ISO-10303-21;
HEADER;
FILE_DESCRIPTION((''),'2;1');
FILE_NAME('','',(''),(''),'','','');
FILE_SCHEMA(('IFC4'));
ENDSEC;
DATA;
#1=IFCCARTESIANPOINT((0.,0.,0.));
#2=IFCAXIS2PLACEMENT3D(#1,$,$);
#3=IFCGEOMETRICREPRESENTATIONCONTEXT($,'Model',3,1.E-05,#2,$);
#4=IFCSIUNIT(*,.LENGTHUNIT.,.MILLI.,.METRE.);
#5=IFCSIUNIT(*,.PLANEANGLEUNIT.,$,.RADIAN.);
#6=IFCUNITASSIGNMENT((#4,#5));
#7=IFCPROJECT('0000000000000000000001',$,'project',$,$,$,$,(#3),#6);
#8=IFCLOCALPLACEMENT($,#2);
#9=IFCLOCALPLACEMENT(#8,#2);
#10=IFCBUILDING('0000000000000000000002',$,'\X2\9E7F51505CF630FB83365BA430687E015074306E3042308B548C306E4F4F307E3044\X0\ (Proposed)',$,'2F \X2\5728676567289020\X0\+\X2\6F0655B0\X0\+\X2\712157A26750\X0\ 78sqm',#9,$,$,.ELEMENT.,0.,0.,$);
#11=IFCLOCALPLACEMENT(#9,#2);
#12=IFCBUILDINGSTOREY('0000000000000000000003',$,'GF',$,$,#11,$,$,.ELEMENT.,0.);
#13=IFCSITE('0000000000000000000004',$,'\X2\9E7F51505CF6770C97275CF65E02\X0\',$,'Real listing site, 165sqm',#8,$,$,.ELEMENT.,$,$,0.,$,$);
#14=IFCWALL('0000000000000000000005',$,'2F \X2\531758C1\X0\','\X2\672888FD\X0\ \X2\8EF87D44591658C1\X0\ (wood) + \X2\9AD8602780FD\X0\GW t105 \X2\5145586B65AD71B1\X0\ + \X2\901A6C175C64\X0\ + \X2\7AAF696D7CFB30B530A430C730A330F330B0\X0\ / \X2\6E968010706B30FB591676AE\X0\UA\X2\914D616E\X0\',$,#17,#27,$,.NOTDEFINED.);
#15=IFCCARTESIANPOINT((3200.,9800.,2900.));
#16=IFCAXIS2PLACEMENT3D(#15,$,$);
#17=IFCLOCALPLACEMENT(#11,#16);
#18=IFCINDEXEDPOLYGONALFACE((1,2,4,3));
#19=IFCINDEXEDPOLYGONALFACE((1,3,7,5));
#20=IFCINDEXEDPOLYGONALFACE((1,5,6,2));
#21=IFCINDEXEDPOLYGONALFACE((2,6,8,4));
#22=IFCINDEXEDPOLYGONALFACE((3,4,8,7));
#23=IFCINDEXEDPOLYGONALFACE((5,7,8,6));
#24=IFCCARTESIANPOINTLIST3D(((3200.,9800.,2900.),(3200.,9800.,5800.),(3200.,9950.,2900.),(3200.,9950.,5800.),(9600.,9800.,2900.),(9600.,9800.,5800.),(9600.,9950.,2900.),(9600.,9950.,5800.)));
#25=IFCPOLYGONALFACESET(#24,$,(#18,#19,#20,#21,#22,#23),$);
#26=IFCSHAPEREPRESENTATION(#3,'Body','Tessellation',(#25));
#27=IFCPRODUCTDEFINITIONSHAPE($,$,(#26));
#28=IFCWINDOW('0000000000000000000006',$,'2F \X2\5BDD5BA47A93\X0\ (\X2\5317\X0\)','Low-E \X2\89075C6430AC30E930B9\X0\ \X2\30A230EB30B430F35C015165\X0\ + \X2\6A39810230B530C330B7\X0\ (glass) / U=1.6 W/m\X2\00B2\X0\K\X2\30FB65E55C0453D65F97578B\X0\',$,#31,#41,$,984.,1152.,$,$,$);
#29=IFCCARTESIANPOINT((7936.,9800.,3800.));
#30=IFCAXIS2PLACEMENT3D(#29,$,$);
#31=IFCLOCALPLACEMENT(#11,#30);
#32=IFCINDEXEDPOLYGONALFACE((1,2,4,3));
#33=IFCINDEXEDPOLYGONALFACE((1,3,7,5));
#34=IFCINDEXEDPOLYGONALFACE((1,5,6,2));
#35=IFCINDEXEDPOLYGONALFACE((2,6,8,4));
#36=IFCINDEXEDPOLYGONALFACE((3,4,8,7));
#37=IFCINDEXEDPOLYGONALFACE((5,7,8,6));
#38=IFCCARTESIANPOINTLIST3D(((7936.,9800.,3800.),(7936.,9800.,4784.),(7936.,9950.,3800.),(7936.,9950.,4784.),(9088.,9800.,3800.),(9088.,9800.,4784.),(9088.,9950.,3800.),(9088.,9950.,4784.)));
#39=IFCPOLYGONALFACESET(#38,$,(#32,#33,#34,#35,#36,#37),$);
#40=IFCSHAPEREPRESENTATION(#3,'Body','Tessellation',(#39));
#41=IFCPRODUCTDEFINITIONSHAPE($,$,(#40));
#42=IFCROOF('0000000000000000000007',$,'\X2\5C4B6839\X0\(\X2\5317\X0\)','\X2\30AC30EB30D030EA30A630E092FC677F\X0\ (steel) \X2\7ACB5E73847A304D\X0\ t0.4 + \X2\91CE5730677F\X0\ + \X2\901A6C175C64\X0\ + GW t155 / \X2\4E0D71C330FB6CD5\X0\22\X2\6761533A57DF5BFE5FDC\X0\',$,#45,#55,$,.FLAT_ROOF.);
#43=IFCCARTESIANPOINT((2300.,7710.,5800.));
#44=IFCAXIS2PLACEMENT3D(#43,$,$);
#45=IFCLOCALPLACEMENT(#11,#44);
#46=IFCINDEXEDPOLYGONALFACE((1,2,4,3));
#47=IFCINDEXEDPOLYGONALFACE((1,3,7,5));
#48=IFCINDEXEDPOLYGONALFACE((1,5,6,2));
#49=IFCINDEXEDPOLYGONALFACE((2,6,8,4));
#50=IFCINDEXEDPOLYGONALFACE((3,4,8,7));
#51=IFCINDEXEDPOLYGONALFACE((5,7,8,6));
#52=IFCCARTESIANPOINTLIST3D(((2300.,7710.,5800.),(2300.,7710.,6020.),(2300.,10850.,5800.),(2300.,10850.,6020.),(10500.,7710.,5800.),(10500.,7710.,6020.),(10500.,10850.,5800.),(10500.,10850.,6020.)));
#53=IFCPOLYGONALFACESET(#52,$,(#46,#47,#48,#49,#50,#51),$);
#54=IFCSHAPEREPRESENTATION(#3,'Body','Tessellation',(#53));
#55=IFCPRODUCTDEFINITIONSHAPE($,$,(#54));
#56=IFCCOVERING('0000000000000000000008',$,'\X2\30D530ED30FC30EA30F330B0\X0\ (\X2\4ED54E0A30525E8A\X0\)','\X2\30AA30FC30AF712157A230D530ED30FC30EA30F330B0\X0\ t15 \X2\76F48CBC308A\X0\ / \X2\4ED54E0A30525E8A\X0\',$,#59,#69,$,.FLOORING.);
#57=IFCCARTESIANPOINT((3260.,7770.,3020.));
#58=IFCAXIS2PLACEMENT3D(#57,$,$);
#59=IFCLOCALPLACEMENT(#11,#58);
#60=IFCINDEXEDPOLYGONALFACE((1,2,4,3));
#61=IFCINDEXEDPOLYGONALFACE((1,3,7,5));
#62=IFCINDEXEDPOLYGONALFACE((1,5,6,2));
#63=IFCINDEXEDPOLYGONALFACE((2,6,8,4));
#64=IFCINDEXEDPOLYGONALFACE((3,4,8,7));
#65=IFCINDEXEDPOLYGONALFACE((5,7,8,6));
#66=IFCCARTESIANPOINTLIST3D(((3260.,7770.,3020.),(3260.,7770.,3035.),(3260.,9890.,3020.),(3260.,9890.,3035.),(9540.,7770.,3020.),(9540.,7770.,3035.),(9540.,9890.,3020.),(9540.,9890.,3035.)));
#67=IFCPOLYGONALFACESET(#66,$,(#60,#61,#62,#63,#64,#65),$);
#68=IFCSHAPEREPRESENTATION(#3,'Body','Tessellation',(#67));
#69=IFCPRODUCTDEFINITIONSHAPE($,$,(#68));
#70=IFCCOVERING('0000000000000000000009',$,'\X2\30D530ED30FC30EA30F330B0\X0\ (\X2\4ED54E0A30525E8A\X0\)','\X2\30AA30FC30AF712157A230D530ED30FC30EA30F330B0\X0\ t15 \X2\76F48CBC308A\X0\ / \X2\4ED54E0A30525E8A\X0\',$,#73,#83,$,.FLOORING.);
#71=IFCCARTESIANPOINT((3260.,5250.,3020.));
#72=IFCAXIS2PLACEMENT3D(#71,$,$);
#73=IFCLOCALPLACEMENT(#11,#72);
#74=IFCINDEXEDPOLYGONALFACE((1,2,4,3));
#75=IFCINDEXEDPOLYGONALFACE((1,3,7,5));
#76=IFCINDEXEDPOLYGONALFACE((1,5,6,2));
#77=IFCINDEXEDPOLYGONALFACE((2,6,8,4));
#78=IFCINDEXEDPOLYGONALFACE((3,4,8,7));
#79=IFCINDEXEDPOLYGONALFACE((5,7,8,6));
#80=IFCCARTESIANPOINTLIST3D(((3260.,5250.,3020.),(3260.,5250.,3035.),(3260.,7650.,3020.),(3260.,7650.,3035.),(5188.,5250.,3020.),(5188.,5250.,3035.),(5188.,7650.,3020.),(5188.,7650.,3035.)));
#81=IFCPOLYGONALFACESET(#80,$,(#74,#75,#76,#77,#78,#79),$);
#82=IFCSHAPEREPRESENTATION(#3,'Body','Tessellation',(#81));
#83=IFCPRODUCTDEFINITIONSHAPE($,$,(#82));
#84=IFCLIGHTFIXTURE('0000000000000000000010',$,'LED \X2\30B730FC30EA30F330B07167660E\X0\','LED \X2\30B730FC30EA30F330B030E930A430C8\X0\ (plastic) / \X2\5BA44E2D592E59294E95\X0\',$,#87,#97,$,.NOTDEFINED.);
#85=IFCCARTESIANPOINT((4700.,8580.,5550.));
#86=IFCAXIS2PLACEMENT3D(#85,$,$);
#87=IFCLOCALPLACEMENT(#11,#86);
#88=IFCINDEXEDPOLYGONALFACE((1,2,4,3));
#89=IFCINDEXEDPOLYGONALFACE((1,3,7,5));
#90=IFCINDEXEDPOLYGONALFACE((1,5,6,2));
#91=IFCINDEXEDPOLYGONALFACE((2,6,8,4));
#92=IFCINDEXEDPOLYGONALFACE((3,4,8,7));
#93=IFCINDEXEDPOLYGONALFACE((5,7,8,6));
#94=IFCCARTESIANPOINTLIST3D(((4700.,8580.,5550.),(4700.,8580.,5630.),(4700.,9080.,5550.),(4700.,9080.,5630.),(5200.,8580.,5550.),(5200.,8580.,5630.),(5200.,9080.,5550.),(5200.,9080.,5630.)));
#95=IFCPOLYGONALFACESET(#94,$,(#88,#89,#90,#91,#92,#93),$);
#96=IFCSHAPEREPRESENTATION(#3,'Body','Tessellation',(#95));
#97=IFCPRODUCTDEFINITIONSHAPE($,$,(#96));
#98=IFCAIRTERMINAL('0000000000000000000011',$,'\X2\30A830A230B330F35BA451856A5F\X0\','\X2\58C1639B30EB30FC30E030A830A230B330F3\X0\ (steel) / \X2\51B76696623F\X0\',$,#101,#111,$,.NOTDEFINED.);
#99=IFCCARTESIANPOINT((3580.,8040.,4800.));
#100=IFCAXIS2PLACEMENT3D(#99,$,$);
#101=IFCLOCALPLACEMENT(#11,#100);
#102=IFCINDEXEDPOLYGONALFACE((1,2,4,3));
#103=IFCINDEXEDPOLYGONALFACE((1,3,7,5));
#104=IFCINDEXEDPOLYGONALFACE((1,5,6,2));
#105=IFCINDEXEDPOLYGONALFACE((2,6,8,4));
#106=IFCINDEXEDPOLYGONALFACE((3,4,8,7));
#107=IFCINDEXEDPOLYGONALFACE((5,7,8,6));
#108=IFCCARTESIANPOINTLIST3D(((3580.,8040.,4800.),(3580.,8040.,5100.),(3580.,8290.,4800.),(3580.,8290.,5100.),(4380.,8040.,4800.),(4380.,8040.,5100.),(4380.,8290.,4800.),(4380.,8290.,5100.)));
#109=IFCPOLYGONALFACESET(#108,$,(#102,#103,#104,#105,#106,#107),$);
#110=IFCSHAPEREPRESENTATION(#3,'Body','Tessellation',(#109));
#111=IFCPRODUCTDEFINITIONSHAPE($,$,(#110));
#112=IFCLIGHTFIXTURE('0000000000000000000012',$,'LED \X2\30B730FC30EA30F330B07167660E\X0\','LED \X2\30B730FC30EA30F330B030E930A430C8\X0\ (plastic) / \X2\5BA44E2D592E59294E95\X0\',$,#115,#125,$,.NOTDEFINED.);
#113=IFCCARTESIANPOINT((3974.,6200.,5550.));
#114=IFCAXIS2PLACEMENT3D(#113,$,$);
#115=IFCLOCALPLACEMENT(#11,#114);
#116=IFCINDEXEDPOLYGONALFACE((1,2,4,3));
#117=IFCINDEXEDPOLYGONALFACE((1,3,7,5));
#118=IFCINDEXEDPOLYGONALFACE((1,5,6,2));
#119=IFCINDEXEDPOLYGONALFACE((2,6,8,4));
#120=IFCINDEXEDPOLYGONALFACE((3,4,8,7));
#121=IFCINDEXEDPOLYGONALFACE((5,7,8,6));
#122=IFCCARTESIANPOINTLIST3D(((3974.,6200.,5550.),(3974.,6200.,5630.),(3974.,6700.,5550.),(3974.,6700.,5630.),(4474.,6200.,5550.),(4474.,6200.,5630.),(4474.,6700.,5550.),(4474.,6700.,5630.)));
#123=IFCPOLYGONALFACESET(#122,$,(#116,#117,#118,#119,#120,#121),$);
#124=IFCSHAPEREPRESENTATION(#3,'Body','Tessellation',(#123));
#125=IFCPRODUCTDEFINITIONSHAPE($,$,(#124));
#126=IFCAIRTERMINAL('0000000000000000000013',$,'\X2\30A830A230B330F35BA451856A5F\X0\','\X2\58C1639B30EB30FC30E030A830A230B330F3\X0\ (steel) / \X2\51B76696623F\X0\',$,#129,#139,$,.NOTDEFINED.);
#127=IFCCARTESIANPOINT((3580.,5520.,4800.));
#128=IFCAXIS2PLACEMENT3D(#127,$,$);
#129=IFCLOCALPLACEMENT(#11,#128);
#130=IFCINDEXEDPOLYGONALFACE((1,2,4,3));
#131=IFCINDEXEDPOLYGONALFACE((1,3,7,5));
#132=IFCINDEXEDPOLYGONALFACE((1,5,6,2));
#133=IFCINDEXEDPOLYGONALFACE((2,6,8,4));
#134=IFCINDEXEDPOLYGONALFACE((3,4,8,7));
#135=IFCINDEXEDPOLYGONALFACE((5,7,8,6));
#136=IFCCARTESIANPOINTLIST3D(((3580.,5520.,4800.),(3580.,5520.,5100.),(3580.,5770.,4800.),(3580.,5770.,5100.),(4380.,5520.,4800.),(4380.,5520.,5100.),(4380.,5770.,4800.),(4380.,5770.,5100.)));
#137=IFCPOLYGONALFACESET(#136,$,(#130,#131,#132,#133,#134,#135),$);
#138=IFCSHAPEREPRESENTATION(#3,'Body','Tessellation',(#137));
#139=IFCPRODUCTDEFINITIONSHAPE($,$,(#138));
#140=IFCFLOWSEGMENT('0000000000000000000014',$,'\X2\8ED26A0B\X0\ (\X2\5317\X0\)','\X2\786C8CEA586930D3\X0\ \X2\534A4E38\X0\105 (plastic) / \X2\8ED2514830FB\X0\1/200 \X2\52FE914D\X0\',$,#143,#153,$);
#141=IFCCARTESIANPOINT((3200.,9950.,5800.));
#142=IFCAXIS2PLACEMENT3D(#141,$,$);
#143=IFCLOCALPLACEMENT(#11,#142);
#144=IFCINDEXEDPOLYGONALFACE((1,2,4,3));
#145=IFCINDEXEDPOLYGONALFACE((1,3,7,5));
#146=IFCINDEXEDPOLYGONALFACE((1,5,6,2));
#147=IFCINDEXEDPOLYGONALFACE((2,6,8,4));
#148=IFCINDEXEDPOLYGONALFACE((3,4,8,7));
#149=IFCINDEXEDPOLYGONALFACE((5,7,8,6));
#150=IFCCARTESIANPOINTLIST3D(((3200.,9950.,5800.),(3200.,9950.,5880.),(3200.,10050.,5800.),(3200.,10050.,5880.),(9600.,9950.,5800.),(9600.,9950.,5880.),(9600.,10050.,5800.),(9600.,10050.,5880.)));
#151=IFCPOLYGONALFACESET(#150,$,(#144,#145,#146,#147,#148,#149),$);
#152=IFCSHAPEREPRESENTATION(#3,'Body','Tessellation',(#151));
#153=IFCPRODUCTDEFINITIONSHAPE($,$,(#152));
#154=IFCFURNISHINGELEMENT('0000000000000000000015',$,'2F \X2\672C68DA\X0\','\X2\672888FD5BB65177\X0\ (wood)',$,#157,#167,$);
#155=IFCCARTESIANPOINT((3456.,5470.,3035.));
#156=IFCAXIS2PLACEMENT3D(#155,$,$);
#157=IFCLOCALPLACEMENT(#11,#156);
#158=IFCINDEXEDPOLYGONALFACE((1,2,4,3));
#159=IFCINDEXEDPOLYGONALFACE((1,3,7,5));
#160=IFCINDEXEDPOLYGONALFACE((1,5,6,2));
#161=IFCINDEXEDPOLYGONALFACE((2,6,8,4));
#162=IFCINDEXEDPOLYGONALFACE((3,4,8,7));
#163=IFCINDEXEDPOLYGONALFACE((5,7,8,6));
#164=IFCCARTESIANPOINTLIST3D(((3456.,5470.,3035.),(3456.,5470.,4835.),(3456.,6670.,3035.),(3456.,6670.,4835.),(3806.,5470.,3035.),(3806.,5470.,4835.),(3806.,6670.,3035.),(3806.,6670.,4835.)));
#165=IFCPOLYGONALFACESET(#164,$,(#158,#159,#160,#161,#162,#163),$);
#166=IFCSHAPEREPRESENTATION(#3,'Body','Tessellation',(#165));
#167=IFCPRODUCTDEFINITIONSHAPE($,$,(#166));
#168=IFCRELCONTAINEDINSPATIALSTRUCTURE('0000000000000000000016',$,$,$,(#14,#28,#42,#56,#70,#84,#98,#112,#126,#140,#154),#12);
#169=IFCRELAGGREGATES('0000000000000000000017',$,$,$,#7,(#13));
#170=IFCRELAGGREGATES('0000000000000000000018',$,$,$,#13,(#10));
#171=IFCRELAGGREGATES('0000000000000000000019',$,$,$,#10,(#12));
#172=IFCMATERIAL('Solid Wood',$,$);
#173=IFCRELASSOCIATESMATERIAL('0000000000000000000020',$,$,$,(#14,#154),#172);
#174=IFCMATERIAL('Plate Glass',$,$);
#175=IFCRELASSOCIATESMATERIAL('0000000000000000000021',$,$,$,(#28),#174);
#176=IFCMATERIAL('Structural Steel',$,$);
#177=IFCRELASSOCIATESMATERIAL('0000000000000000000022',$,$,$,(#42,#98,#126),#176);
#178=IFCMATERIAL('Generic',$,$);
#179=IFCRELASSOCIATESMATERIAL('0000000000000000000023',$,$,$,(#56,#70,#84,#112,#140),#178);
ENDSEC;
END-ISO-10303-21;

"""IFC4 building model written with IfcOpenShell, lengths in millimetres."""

from ifc_helpers import new_model, si_unit, frame, frame_2d, origin, place, context, project, spatial, rectangle, extrude, material, element, fill, save


model = new_model("IFC4")

# Units and contexts
model_context = context("Model", 3, precision=1e-05, world=origin())
ifc_project = project(units=[si_unit("LENGTHUNIT", "METRE", prefix="MILLI"), si_unit("PLANEANGLEUNIT", "RADIAN")], contexts=[model_context])

# Site, building, storey
site_placement = place(None, origin())
site = spatial("IfcSite", under=ifc_project, at=site_placement, Name="鹿児島県霧島市", ObjectType="Real listing site, 165sqm", CompositionType="ELEMENT", RefElevation=0.0)
building_placement = place(site_placement, origin())
building = spatial("IfcBuilding", under=site, at=building_placement, Name="鹿児島・茶室と縁側のある和の住まい (Proposed)", ObjectType="2F 在来木造+漆喰+無垢材 78sqm", CompositionType="ELEMENT", ElevationOfRefHeight=0.0, ElevationOfTerrain=0.0)
storey_placement = place(building_placement, origin())
storey = spatial("IfcBuildingStorey", under=building, at=storey_placement, Name="GF", CompositionType="ELEMENT", Elevation=0.0)

# Shared definitions
ifc_material_1 = material(Name="Solid Wood")

# Wall, opening, window
wall_placement = place(storey_placement, frame((3200.0, 9800.0, 2900.0)))
wall = element("IfcWall", 1, at=wall_placement, inside=storey, material=ifc_material_1, Name="2F 北壁", Description="木製 軸組外壁 (wood) + 高性能GW t105 充填断熱 + 通気層 + 窯業系サイディング / 準耐火・外皮UA配慮", PredefinedType="NOTDEFINED", context=model_context, shape_type="SweptSolid", body=[
    extrude(rectangle(XDim=6400.0, YDim=150.0, at=frame_2d((3200.0, 75.0))), frame((3200.0, 9800.0, 2900.0)), (0.0, 0.0, 1.0), 2900.0),
])
opening_placement = place(storey_placement, frame((7936.0, 9800.0, 3800.0)))
opening = element("IfcOpeningElement", 2, at=opening_placement, cuts=wall, PredefinedType="NOTDEFINED", context=model_context, shape_type="SweptSolid", body=[
    extrude(rectangle(XDim=1152.0, YDim=150.0, at=frame_2d((576.0, 75.0))), frame((7936.0, 9800.0, 3800.0)), (0.0, 0.0, 1.0), 984.0),
])
ifc_material_2 = material(Name="Plate Glass")
window_placement = place(storey_placement, frame((7936.0, 9800.0, 3800.0)))
window = element("IfcWindow", 3, at=window_placement, inside=storey, material=ifc_material_2, Name="2F 寝室窓 (北)", Description="Low-E 複層ガラス アルゴン封入 + 樹脂サッシ (glass) / U=1.6 W/m²K・日射取得型", OverallHeight=984.0, OverallWidth=1152.0, context=model_context, shape_type="SweptSolid", body=[
    extrude(rectangle(XDim=1152.0, YDim=150.0, at=frame_2d((576.0, 75.0))), frame((7936.0, 9800.0, 3800.0)), (0.0, 0.0, 1.0), 984.0),
])
fill(opening, window)

# Roof
ifc_material_3 = material(Name="Structural Steel")
for number, where, name in (
    (4, (2300.0, 7710.0, 5800.0), "屋根(北)"),
):
    element("IfcRoof", number, at=place(storey_placement, frame(where)), inside=storey, material=ifc_material_3, Name=name, Description="ガルバリウム鋼板 (steel) 立平葺き t0.4 + 野地板 + 通気層 + GW t155 / 不燃・法22条区域対応", PredefinedType="FLAT_ROOF", context=model_context, shape_type="SweptSolid", body=[
        extrude(rectangle(XDim=8200.0, YDim=3140.0, at=frame_2d((4100.0, 1570.0))), frame((2300.0, 7710.0, 5800.0)), (0.0, 0.0, 1.0), 220.0),
    ])

# Coverings
ifc_material_4 = material(Name="Generic")
covering_1_placement = place(storey_placement, frame((3260.0, 7770.0, 3020.0)))
element("IfcCovering", 5, at=covering_1_placement, inside=storey, material=ifc_material_4, Name="フローリング (仕上げ床)", Description="オーク無垢フローリング t15 直貼り / 仕上げ床", PredefinedType="FLOORING", context=model_context, shape_type="SweptSolid", body=[
    extrude(rectangle(XDim=6280.0, YDim=2120.0, at=frame_2d((3140.0, 1060.0))), frame((3260.0, 7770.0, 3020.0)), (0.0, 0.0, 1.0), 15.0),
])
covering_2_placement = place(storey_placement, frame((3260.0, 5250.0, 3020.0)))
element("IfcCovering", 6, at=covering_2_placement, inside=storey, material=ifc_material_4, Name="フローリング (仕上げ床)", Description="オーク無垢フローリング t15 直貼り / 仕上げ床", PredefinedType="FLOORING", context=model_context, shape_type="SweptSolid", body=[
    extrude(rectangle(XDim=1928.0, YDim=2400.0, at=frame_2d((964.0, 1200.0))), frame((3260.0, 5250.0, 3020.0)), (0.0, 0.0, 1.0), 15.0),
])

# Light fixture
light_fixture_1_placement = place(storey_placement, frame((4700.0, 8580.0, 5550.0)))
element("IfcLightFixture", 7, at=light_fixture_1_placement, inside=storey, material=ifc_material_4, Name="LED シーリング照明", Description="LED シーリングライト (plastic) / 室中央天井", PredefinedType="NOTDEFINED", context=model_context, shape_type="SweptSolid", body=[
    extrude(rectangle(XDim=500.0, YDim=500.0, at=frame_2d((250.0, 250.0))), frame((4700.0, 8580.0, 5550.0)), (0.0, 0.0, 1.0), 80.0),
])

# Air terminal
air_terminal_1_placement = place(storey_placement, frame((3580.0, 8040.0, 4800.0)))
element("IfcAirTerminal", 8, at=air_terminal_1_placement, inside=storey, material=ifc_material_3, Name="エアコン室内機", Description="壁掛ルームエアコン (steel) / 冷暖房", PredefinedType="NOTDEFINED", context=model_context, shape_type="SweptSolid", body=[
    extrude(rectangle(XDim=800.0, YDim=250.0, at=frame_2d((400.0, 125.0))), frame((3580.0, 8040.0, 4800.0)), (0.0, 0.0, 1.0), 300.0),
])

# Light fixture
light_fixture_2_placement = place(storey_placement, frame((3974.0, 6200.0, 5550.0)))
element("IfcLightFixture", 9, at=light_fixture_2_placement, inside=storey, material=ifc_material_4, Name="LED シーリング照明", Description="LED シーリングライト (plastic) / 室中央天井", PredefinedType="NOTDEFINED", context=model_context, shape_type="SweptSolid", body=[
    extrude(rectangle(XDim=500.0, YDim=500.0, at=frame_2d((250.0, 250.0))), frame((3974.0, 6200.0, 5550.0)), (0.0, 0.0, 1.0), 80.0),
])

# Air terminal
air_terminal_2_placement = place(storey_placement, frame((3580.0, 5520.0, 4800.0)))
element("IfcAirTerminal", 10, at=air_terminal_2_placement, inside=storey, material=ifc_material_3, Name="エアコン室内機", Description="壁掛ルームエアコン (steel) / 冷暖房", PredefinedType="NOTDEFINED", context=model_context, shape_type="SweptSolid", body=[
    extrude(rectangle(XDim=800.0, YDim=250.0, at=frame_2d((400.0, 125.0))), frame((3580.0, 5520.0, 4800.0)), (0.0, 0.0, 1.0), 300.0),
])

# Flow segment
flow_segment_placement = place(storey_placement, frame((3200.0, 9950.0, 5800.0)))
element("IfcFlowSegment", 11, at=flow_segment_placement, inside=storey, material=ifc_material_4, Name="軒樋 (北)", Description="硬質塩ビ 半丸105 (plastic) / 軒先・1/200 勾配", context=model_context, shape_type="SweptSolid", body=[
    extrude(rectangle(XDim=6400.0, YDim=100.0, at=frame_2d((3200.0, 50.0))), frame((3200.0, 9950.0, 5800.0)), (0.0, 0.0, 1.0), 80.0),
])

# Furnishing element
furnishing_placement = place(storey_placement, frame((3456.0, 5470.0, 3035.0)))
element("IfcFurnishingElement", 12, at=furnishing_placement, inside=storey, material=ifc_material_1, Name="2F 本棚", Description="木製家具 (wood)", context=model_context, shape_type="SweptSolid", body=[
    extrude(rectangle(XDim=350.0, YDim=1200.0, at=frame_2d((175.0, 600.0))), frame((3456.0, 5470.0, 3035.0)), (0.0, 0.0, 1.0), 1800.0),
])

save(model, "model.ifc")
